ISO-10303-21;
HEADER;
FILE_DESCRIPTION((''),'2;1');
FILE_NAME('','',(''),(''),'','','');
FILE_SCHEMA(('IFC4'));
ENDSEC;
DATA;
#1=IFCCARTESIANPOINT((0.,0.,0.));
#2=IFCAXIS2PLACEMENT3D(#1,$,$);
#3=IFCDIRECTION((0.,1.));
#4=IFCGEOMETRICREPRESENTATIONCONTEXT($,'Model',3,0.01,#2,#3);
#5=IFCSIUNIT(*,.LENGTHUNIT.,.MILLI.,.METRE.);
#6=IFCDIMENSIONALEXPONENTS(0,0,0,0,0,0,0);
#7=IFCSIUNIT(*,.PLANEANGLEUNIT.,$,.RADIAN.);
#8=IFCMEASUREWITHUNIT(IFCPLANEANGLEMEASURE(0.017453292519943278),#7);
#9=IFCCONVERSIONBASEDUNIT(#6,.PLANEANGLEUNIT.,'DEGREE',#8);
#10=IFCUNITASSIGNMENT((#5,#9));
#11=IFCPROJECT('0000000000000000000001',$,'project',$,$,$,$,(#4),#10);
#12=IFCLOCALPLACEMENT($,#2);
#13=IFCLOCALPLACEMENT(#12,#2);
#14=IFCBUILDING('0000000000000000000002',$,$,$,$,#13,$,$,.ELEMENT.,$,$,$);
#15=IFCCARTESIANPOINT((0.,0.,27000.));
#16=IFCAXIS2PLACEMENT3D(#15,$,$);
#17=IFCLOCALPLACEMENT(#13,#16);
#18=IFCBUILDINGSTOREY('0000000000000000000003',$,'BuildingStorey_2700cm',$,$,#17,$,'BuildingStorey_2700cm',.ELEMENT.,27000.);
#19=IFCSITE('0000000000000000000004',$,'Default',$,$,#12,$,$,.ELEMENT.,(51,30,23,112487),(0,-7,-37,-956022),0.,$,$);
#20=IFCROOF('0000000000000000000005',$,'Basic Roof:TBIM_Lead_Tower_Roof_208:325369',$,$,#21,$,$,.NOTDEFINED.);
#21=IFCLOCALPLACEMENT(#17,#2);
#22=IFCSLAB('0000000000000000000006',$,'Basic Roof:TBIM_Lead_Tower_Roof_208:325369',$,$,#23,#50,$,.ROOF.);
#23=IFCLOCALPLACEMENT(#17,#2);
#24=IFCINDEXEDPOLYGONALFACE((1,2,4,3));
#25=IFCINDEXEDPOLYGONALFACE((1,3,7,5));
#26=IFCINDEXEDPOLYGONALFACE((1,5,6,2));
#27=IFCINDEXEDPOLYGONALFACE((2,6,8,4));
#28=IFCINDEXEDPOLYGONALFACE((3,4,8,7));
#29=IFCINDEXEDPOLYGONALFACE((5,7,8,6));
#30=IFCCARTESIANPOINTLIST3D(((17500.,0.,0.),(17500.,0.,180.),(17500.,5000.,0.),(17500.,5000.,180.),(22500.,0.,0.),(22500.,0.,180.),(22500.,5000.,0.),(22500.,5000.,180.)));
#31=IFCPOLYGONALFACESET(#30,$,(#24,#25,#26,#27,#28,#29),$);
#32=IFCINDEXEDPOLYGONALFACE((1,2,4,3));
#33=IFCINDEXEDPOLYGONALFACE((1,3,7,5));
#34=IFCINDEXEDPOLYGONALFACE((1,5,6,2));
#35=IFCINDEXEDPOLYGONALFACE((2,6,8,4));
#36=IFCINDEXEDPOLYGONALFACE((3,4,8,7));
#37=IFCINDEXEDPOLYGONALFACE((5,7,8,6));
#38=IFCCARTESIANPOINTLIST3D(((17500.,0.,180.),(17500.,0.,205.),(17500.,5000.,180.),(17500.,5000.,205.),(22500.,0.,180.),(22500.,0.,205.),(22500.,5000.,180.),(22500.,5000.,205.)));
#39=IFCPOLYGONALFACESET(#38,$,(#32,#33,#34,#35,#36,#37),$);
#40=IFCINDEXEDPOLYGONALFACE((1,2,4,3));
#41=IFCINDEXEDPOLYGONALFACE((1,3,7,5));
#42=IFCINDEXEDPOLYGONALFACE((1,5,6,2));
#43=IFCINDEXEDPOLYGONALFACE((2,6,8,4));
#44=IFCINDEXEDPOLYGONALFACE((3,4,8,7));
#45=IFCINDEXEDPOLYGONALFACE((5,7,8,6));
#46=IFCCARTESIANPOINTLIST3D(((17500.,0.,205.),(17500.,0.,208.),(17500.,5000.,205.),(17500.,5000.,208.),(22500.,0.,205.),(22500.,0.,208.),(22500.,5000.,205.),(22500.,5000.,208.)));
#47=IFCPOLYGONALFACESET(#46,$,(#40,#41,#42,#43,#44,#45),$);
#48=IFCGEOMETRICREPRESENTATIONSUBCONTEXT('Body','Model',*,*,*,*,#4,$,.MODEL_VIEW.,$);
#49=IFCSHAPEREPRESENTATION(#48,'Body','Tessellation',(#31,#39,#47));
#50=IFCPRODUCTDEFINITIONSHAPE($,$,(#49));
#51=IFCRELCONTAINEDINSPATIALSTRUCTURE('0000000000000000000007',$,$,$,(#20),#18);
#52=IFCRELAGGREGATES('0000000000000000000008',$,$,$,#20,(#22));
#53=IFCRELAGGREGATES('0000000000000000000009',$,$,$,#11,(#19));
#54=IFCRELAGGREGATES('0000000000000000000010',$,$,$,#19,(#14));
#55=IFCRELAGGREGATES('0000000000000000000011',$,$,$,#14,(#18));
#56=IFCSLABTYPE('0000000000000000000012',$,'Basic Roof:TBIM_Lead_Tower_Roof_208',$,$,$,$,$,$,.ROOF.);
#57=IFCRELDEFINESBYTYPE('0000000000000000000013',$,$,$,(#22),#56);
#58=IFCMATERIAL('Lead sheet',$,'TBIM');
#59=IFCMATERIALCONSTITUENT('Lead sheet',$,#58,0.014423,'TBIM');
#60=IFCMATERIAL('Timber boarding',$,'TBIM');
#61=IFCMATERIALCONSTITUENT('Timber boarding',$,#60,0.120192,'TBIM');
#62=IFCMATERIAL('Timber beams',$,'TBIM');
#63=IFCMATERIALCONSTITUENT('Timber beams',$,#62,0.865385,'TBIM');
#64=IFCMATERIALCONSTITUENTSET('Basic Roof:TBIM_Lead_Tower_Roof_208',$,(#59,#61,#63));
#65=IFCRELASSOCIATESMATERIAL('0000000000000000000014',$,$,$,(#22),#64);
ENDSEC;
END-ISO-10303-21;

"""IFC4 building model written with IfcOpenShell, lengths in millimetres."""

from ifc_helpers import new_model, entity, si_unit, converted_unit, direction, frame, origin, place, context, subcontext, project, spatial, indexed_curve, outline, extrude, material, constituent, constituent_set, type_object, element, aggregate, save


model = new_model("IFC4")

# Units and contexts
model_context = context("Model", 3, precision=0.01, world=origin(), true_north=direction((0.0, 1.0)))
body_context = subcontext(model_context, "Body", "Model", "MODEL_VIEW")
ifc_project = project(units=[si_unit("LENGTHUNIT", "METRE", prefix="MILLI"), converted_unit("PLANEANGLEUNIT", "DEGREE", entity("IfcPlaneAngleMeasure", 0.017453292519943278), si_unit("PLANEANGLEUNIT", "RADIAN"), dimensions=[0, 0, 0, 0, 0, 0, 0])], contexts=[model_context])

# Site, building, storey
site_placement = place(None, origin())
site = spatial("IfcSite", under=ifc_project, at=site_placement, Name="Default", CompositionType="ELEMENT", RefLatitude=(51, 30, 23, 112487), RefLongitude=(0, -7, -37, -956022), RefElevation=0.0)
building_placement = place(site_placement, origin())
building = spatial("IfcBuilding", under=site, at=building_placement, CompositionType="ELEMENT")
storey_placement = place(building_placement, frame((0.0, 0.0, 27000.0)))
storey = spatial("IfcBuildingStorey", under=building, at=storey_placement, Name="BuildingStorey_2700cm", LongName="BuildingStorey_2700cm", CompositionType="ELEMENT", Elevation=27000.0)

# Roof, slab
roof_placement = place(storey_placement, frame((17500.0, 0.0, 0.0)))
roof = element("IfcRoof", 1, at=roof_placement, inside=storey, Name="Basic Roof:TBIM_Lead_Tower_Roof_208:325369", PredefinedType="NOTDEFINED")
ifc_material_1 = material(Name="Lead sheet", Category="TBIM")
ifc_constituent_1 = constituent(ifc_material_1, Name="Lead sheet", Category="TBIM", fraction=0.014423)
ifc_material_2 = material(Name="Timber boarding", Category="TBIM")
ifc_constituent_2 = constituent(ifc_material_2, Name="Timber boarding", Category="TBIM", fraction=0.120192)
ifc_material_3 = material(Name="Timber beams", Category="TBIM")
ifc_constituent_3 = constituent(ifc_material_3, Name="Timber beams", Category="TBIM", fraction=0.865385)
ifc_constituent_set = constituent_set(constituents=[ifc_constituent_1, ifc_constituent_2, ifc_constituent_3], Name="Basic Roof:TBIM_Lead_Tower_Roof_208")
slab_type = type_object("IfcSlabType", Name="Basic Roof:TBIM_Lead_Tower_Roof_208", PredefinedType="ROOF")
slab_placement = place(roof_placement, origin())
slab = element("IfcSlab", 2, at=slab_placement, type_object=slab_type, material=ifc_constituent_set, Name="Basic Roof:TBIM_Lead_Tower_Roof_208:325369", PredefinedType="ROOF", context=body_context, shape_type="SweptSolid", body=[
    extrude(outline(indexed_curve([(-2500.0, 2500.0), (-2500.0, -2500.0), (2500.0, -2500.0), (2500.0, 2500.0), (-2500.0, 2500.0)], self_intersect=False)), frame((2500.0, 2500.0, 0.0)), (0.0, 0.0, 1.0), 180.0),
    extrude(outline(indexed_curve([(-2500.0, 2500.0), (-2500.0, -2500.0), (2500.0, -2500.0), (2500.0, 2500.0), (-2500.0, 2500.0)], self_intersect=False)), frame((2500.0, 2500.0, 180.0)), (0.0, 0.0, 1.0), 25.0),
    extrude(outline(indexed_curve([(-2500.0, 2500.0), (-2500.0, -2500.0), (2500.0, -2500.0), (2500.0, 2500.0), (-2500.0, 2500.0)], self_intersect=False)), frame((2500.0, 2500.0, 205.0)), (0.0, 0.0, 1.0), 3.0),
])
aggregate(roof, [slab])

save(model, "model.ifc")
